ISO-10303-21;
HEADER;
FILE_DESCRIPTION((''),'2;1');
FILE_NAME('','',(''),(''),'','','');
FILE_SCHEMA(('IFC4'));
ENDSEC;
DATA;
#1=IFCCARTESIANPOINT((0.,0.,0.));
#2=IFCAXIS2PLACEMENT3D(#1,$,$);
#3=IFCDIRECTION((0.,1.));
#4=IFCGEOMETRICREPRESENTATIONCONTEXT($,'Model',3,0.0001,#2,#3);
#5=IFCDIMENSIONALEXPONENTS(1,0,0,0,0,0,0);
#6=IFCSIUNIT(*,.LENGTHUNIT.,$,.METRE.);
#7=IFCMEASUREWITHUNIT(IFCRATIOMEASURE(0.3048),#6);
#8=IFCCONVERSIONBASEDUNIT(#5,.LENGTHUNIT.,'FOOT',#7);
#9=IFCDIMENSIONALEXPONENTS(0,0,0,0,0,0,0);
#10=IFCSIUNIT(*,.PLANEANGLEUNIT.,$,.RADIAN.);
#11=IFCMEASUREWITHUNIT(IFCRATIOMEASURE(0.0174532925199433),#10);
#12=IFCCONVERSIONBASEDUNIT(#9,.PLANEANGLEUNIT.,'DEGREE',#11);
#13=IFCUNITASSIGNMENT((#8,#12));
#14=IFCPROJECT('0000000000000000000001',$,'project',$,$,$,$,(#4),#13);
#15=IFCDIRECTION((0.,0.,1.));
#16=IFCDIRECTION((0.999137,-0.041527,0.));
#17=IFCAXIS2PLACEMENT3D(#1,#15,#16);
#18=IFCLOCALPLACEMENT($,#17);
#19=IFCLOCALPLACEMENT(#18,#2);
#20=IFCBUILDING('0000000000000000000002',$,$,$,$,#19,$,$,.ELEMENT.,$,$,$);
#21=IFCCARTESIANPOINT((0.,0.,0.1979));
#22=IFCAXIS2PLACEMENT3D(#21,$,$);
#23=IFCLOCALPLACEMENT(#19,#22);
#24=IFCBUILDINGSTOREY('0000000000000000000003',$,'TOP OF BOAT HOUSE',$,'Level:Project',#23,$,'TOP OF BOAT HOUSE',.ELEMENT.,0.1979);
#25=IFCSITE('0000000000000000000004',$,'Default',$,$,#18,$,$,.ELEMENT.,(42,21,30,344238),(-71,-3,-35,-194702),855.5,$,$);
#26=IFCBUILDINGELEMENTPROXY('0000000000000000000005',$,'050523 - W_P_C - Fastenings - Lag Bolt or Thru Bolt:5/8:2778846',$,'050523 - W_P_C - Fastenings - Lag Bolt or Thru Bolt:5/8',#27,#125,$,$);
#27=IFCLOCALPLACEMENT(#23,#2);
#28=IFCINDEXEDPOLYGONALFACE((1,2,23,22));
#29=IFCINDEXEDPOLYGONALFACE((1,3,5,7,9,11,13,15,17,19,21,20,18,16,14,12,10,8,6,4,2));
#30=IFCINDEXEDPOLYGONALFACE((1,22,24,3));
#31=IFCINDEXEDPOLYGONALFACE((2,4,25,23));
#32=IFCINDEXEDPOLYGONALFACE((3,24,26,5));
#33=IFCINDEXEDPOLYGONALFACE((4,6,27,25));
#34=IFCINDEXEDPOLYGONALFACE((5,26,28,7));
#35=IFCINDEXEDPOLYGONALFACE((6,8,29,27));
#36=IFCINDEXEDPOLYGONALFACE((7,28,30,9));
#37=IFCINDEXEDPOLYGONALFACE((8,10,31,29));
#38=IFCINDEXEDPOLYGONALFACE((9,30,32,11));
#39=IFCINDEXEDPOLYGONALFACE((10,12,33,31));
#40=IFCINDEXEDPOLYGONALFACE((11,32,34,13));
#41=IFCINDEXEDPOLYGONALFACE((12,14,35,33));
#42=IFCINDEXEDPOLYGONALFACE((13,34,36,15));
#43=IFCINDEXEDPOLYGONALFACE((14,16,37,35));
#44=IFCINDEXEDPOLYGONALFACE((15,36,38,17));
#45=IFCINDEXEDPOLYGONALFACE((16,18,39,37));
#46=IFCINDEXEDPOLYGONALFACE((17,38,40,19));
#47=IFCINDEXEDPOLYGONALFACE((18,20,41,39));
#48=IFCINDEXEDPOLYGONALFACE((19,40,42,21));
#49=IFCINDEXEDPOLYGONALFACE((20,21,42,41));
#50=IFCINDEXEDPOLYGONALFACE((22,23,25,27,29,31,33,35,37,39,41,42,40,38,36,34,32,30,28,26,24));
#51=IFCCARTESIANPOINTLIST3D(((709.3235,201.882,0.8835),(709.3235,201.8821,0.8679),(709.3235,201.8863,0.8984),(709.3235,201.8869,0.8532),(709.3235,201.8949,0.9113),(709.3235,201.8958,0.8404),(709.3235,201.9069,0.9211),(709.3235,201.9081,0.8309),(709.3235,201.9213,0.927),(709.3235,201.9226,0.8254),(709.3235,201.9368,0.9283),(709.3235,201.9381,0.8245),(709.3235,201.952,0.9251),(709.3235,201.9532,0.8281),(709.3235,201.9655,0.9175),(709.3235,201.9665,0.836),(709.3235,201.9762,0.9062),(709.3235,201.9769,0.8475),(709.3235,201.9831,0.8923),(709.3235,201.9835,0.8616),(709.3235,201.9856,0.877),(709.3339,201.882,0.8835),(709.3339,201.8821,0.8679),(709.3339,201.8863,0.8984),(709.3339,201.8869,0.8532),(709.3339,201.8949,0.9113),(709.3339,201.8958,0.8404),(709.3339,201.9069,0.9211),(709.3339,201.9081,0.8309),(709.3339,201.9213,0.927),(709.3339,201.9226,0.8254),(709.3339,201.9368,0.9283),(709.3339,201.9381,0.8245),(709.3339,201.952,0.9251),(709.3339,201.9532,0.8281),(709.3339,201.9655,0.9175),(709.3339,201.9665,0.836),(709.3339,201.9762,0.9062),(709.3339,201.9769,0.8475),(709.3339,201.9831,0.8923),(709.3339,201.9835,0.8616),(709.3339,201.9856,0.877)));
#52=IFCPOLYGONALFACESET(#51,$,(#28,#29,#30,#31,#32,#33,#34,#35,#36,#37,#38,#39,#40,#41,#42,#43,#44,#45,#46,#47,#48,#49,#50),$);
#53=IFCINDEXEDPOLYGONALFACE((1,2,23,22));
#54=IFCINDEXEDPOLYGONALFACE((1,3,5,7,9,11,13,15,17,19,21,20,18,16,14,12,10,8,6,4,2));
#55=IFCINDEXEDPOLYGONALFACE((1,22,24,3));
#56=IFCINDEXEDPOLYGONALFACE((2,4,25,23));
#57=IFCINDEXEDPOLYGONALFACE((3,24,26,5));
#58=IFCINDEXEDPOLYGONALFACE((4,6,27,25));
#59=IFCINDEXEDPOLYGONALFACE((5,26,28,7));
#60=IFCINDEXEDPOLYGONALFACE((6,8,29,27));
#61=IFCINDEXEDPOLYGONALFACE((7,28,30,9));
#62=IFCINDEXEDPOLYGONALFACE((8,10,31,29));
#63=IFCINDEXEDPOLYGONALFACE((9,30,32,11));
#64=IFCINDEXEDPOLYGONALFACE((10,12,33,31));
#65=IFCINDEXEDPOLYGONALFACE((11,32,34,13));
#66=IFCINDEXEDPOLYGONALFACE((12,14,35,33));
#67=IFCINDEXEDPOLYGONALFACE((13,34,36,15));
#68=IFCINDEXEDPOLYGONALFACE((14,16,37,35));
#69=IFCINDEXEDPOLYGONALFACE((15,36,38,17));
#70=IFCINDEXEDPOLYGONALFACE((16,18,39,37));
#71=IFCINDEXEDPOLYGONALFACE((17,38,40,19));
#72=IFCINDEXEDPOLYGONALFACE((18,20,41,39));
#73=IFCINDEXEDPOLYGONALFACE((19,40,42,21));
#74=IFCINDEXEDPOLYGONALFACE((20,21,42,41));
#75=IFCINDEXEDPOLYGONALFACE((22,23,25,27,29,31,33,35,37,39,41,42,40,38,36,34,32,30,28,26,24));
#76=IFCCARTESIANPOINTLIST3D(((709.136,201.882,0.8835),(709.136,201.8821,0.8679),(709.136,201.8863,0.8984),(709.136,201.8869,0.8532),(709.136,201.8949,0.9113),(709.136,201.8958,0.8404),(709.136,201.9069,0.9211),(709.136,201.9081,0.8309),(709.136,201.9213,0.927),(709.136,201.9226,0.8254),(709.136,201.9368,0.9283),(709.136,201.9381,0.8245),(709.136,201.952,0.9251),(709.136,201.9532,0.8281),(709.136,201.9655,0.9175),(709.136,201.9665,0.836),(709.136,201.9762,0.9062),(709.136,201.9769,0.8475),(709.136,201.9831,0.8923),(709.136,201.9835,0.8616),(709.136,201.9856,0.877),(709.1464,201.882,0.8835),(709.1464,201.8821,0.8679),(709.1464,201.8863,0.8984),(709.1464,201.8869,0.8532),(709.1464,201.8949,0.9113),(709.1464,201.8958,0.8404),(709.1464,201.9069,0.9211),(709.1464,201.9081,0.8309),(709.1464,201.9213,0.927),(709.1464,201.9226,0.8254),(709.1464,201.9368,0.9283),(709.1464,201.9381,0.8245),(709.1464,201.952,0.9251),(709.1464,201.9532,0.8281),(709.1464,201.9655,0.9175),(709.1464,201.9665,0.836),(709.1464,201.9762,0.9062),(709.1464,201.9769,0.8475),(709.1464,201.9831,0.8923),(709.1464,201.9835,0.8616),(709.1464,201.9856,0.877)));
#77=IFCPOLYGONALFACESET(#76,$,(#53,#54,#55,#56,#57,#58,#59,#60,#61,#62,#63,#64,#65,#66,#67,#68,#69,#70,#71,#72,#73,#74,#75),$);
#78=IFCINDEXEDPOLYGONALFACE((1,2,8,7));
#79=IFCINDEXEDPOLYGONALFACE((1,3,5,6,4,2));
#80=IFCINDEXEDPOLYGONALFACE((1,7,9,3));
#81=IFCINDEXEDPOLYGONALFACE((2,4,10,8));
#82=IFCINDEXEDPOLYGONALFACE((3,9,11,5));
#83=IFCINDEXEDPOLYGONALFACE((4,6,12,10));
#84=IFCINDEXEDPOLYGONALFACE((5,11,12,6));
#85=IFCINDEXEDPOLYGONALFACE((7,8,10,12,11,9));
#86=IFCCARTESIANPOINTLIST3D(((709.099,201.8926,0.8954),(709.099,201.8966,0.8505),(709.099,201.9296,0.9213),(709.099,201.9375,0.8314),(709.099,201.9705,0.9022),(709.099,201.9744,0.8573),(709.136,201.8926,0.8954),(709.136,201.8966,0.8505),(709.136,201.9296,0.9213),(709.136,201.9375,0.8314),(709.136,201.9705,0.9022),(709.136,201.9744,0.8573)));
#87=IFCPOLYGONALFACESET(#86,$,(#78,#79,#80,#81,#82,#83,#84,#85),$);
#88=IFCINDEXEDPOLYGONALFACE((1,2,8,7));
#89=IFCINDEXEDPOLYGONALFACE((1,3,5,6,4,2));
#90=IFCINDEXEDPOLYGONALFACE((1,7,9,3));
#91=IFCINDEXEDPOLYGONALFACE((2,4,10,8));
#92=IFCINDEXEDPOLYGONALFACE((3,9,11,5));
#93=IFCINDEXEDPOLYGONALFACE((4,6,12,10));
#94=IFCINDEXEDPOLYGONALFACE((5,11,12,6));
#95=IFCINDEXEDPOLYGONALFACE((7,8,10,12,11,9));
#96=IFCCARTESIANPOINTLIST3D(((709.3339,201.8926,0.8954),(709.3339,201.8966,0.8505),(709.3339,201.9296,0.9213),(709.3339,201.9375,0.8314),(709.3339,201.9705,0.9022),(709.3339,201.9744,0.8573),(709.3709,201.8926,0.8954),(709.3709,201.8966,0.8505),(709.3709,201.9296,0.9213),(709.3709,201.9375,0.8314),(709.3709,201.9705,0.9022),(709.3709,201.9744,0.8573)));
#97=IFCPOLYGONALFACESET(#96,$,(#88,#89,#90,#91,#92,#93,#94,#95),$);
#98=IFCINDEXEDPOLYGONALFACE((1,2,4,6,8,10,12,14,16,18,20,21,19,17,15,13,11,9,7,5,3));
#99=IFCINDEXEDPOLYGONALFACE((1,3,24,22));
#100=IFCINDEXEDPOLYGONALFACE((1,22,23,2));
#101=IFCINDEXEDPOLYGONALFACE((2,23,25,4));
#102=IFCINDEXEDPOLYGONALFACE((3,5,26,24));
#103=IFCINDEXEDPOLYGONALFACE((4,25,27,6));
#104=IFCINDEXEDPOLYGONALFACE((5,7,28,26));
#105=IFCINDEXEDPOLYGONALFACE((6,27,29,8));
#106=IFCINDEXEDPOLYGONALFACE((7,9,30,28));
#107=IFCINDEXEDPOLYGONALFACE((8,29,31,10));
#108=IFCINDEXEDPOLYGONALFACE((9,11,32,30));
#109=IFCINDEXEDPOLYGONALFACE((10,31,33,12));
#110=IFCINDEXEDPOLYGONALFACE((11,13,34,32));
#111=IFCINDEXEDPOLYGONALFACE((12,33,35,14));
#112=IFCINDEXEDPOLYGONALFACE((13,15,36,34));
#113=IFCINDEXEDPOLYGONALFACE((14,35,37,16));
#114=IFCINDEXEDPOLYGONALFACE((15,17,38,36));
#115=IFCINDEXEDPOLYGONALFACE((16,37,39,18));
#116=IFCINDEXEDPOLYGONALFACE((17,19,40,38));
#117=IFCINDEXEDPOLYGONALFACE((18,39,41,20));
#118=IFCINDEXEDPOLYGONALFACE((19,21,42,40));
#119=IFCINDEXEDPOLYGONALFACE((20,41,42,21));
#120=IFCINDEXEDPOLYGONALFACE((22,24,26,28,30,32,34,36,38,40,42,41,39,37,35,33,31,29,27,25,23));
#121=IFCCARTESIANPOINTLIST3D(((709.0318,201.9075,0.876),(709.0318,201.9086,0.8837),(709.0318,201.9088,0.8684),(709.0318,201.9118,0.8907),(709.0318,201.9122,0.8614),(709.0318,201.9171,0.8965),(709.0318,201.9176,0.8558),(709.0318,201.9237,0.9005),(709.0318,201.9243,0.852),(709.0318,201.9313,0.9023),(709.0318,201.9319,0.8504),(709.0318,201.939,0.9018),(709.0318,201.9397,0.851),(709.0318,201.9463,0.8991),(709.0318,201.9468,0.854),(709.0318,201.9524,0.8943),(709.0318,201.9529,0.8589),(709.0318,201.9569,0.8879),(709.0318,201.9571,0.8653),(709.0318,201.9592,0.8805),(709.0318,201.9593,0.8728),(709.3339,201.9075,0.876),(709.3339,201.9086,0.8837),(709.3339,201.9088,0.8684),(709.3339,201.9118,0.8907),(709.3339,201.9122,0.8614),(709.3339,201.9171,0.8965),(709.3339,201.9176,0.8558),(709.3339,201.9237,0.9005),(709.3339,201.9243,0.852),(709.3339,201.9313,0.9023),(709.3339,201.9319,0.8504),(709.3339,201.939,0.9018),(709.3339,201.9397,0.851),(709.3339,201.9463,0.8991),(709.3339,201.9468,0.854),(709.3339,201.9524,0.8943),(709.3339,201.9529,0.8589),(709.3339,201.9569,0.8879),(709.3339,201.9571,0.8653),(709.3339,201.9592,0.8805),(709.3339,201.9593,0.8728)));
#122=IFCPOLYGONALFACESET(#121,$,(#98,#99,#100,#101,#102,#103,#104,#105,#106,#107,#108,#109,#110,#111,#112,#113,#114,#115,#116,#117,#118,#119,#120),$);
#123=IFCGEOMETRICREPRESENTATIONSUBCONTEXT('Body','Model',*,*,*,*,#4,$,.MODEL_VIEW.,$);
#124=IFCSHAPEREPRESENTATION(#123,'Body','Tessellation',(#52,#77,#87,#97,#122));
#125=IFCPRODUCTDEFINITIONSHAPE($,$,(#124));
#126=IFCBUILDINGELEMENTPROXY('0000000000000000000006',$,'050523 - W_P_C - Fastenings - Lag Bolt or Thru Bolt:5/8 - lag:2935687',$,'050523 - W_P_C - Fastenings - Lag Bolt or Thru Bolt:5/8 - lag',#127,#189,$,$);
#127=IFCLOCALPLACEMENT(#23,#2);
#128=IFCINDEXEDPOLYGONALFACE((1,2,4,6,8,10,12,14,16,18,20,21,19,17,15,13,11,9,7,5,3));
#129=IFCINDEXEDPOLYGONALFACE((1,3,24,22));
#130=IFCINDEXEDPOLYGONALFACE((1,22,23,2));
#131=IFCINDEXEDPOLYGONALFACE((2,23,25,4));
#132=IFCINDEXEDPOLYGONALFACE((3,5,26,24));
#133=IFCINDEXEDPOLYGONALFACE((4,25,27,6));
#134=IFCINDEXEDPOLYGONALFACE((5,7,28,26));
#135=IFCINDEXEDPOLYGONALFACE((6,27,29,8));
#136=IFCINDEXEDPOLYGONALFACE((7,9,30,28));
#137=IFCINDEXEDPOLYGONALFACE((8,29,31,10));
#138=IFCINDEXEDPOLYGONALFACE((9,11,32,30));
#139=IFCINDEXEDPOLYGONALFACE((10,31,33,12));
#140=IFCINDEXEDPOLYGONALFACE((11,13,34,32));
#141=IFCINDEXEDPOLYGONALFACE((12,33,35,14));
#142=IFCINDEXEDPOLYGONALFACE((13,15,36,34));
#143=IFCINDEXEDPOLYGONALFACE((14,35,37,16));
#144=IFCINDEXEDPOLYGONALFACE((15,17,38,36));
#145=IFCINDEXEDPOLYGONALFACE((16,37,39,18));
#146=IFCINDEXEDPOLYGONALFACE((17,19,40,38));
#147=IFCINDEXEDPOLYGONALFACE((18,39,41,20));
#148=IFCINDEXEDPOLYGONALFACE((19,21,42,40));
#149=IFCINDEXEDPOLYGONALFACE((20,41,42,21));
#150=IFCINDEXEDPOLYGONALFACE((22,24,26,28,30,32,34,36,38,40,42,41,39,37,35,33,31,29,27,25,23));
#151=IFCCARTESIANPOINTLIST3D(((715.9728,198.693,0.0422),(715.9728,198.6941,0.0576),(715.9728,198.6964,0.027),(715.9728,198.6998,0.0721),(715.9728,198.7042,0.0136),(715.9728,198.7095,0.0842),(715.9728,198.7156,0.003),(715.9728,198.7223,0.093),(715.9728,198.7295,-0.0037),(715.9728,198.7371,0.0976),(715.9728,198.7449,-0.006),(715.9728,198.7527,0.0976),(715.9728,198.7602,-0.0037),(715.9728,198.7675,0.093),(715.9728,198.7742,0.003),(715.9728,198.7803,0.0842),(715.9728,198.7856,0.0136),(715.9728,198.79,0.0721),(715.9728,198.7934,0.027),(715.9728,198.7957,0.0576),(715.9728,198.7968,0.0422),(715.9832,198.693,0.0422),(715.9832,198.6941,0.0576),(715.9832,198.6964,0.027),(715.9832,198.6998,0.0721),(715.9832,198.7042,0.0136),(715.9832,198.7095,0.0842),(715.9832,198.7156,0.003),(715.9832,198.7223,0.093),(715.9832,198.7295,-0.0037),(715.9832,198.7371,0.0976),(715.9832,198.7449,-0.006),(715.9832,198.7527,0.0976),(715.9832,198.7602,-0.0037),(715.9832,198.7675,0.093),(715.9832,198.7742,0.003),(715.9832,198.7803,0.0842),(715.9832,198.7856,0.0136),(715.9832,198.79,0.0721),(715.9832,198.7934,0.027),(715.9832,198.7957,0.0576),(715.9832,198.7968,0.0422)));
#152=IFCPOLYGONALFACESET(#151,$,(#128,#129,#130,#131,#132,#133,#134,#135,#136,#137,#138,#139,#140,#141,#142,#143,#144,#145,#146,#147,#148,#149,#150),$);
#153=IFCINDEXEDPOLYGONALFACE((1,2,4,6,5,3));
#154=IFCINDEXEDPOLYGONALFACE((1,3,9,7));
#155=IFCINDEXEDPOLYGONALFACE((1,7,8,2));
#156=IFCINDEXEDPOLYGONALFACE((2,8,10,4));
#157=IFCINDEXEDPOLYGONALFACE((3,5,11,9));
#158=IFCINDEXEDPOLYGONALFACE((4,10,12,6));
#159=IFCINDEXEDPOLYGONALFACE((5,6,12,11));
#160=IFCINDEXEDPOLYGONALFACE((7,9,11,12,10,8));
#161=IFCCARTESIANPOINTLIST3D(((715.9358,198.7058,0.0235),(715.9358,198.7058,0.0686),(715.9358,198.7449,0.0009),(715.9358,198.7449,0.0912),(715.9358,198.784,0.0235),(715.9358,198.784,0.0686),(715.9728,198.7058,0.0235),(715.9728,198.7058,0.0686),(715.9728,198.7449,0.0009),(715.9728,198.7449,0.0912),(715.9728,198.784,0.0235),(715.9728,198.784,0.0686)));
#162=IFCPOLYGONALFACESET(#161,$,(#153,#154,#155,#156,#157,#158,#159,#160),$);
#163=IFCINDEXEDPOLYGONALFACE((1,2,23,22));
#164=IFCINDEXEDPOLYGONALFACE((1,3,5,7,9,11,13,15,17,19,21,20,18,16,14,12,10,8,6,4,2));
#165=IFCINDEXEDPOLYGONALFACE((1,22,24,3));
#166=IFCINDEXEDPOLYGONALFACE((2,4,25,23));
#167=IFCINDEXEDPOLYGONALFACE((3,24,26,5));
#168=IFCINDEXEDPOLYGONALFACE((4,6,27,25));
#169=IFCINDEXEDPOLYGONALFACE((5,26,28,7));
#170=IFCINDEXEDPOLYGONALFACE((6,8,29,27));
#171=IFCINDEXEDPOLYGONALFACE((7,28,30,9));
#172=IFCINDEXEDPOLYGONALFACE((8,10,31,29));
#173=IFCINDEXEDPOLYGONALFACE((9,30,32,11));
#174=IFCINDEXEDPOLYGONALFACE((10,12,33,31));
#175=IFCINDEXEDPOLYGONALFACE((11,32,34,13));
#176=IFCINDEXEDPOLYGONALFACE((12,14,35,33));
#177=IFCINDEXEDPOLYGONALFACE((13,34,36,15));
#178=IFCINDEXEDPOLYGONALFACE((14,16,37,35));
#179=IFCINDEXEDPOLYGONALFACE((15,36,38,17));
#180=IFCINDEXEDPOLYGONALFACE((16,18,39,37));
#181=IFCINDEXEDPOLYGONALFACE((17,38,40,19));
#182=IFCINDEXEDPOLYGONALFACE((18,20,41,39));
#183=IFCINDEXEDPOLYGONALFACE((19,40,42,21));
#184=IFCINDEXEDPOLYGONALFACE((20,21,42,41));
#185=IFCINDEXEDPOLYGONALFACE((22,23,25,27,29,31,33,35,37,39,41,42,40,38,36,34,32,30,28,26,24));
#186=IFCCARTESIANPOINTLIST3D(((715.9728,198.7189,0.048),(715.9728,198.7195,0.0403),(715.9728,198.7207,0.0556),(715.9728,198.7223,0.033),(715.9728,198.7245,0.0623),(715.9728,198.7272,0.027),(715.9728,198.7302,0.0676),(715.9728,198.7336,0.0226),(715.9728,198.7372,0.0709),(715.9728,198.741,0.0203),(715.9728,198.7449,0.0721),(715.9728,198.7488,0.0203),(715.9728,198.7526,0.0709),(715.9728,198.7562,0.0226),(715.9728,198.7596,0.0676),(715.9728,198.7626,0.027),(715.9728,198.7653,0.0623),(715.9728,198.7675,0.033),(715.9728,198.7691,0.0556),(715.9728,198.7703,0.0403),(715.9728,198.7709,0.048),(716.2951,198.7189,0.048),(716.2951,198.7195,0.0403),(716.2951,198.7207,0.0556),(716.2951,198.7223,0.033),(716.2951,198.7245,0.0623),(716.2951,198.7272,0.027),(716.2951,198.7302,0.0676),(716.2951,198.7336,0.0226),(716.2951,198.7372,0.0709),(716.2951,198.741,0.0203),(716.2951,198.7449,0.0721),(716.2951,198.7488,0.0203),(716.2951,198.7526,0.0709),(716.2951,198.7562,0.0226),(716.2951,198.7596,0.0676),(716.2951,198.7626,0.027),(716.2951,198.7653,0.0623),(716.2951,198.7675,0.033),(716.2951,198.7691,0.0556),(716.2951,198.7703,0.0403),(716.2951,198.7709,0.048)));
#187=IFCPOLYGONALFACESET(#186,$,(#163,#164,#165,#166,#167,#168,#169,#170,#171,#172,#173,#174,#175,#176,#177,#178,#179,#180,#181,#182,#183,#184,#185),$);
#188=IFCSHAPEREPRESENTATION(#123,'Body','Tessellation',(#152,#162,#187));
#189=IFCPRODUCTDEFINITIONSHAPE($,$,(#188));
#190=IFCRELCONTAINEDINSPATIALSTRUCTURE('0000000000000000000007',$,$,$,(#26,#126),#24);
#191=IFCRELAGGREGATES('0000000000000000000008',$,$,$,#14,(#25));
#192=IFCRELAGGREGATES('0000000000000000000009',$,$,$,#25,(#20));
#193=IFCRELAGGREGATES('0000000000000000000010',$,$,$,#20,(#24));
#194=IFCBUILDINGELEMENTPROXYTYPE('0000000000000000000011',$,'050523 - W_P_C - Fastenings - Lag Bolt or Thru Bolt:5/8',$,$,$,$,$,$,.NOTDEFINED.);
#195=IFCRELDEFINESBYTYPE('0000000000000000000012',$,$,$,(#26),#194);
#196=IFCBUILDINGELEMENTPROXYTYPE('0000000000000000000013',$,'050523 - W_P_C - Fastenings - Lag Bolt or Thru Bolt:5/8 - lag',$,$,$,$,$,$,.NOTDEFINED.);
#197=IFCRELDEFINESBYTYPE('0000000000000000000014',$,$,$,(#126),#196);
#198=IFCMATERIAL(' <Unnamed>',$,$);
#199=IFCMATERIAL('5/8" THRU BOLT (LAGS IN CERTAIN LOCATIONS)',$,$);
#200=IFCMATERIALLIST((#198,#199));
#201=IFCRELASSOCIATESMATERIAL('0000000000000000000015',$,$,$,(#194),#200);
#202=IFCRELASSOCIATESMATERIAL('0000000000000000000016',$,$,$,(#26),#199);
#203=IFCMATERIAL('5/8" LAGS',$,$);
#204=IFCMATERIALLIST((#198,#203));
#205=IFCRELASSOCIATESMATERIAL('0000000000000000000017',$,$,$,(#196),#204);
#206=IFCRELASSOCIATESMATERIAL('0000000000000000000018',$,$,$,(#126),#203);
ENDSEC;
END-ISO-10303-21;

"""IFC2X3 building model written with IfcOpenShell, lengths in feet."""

from ifc_helpers import new_model, entity, si_unit, converted_unit, direction, frame, frame_2d, origin, place, context, subcontext, project, spatial, polyline, circle, outline, extrude, source, transform, mapped, material, material_list, type_object, type_shapes, element, save


model = new_model("IFC2X3")

# Units and contexts
model_context = context("Model", 3, precision=0.0001, world=origin(), true_north=direction((0.0, 1.0)))
body_context = subcontext(model_context, "Body", "Model", "MODEL_VIEW")
ifc_project = project(units=[converted_unit("LENGTHUNIT", "FOOT", entity("IfcRatioMeasure", 0.3048), si_unit("LENGTHUNIT", "METRE"), dimensions=[1, 0, 0, 0, 0, 0, 0]), converted_unit("PLANEANGLEUNIT", "DEGREE", entity("IfcRatioMeasure", 0.0174532925199433), si_unit("PLANEANGLEUNIT", "RADIAN"), dimensions=[0, 0, 0, 0, 0, 0, 0])], contexts=[model_context])

# Site, building, storey
site_placement = place(None, frame((0.0, 0.0, 0.0), z_axis=(0.0, 0.0, 1.0), x_axis=(0.999137, -0.041527, 0.0)))
site = spatial("IfcSite", under=ifc_project, at=site_placement, Name="Default", CompositionType="ELEMENT", RefLatitude=(42, 21, 30, 344238), RefLongitude=(-71, -3, -35, -194702), RefElevation=855.5)
building_placement = place(site_placement, origin())
building = spatial("IfcBuilding", under=site, at=building_placement, CompositionType="ELEMENT")
storey_placement = place(building_placement, frame((0.0, 0.0, 0.1979)))
storey = spatial("IfcBuildingStorey", under=building, at=storey_placement, Name="TOP OF BOAT HOUSE", ObjectType="Level:Project", LongName="TOP OF BOAT HOUSE", CompositionType="ELEMENT", Elevation=0.1979)

# Building element proxies
ifc_material_1 = material(Name="5/8\" THRU BOLT (LAGS IN CERTAIN LOCATIONS)")
ifc_material_2 = material(Name=" <Unnamed>")
ifc_material_list_1 = material_list([ifc_material_2, ifc_material_1])
building_element_proxy_type_1 = type_object("IfcBuildingElementProxyType", Name="050523 - W_P_C - Fastenings - Lag Bolt or Thru Bolt:5/8", PredefinedType="NOTDEFINED", material=ifc_material_list_1)
shared_shape_1 = source(origin(), body_context, "Body", "SweptSolid", [
    extrude(circle(Radius=0.0521, at=frame_2d((0.0, 0.0), x_axis=(1.0, 0.0))), frame((0.0, 0.0, 0.0), z_axis=(0.0, 0.0, 1.0), x_axis=(0.0, 1.0, 0.0)), (0.0, 0.0, 1.0), 0.0104),
    extrude(circle(Radius=0.0521, at=frame_2d((0.0, 0.0), x_axis=(1.0, 0.0))), frame((0.0, 0.0, -0.1875), z_axis=(0.0, 0.0, 1.0), x_axis=(0.0, 1.0, 0.0)), (0.0, 0.0, 1.0), 0.0104),
    extrude(outline(polyline([(-0.0226, -0.0391), (0.0226, -0.0391), (0.0451, 0.0), (0.0226, 0.0391), (-0.0226, 0.0391), (-0.0451, 0.0), (-0.0226, -0.0391)])), frame((0.0, 0.0, -0.2245), z_axis=(0.0, 0.0, 1.0), x_axis=(0.0, -1.0, 0.0)), (0.0, 0.0, 1.0), 0.037),
    extrude(outline(polyline([(-0.0226, -0.0391), (0.0226, -0.0391), (0.0451, 0.0), (0.0226, 0.0391), (-0.0226, 0.0391), (-0.0451, 0.0), (-0.0226, -0.0391)])), frame((0.0, 0.0, 0.0104), z_axis=(0.0, 0.0, 1.0), x_axis=(0.866025, -0.5, 0.0)), (0.0, 0.0, 1.0), 0.037),
    extrude(circle(Radius=0.026, at=frame_2d((0.0, 0.0), x_axis=(1.0, 0.0))), frame((0.0, 0.0, -0.2917), z_axis=(0.0, 0.0, 1.0), x_axis=(0.0, -1.0, 0.0)), (0.0, 0.0, 1.0), 0.3021),
])
type_shapes(building_element_proxy_type_1, [shared_shape_1])
for number, where, z_axis, x_axis, name in (
    (1, (709.3235, 201.9335, 0.8763), (1.0, 0.0, 0.0), (0.0, -0.996195, -0.087156), "050523 - W_P_C - Fastenings - Lag Bolt or Thru Bolt:5/8:2778846"),
):
    element("IfcBuildingElementProxy", number, at=place(storey_placement, frame(where, z_axis=z_axis, x_axis=x_axis)), inside=storey, type_object=building_element_proxy_type_1, material=ifc_material_1, Name=name, ObjectType="050523 - W_P_C - Fastenings - Lag Bolt or Thru Bolt:5/8", context=body_context, shape_type="MappedRepresentation", body=[
        mapped(shared_shape_1, transform((0.0, 0.0, 0.0), scale=1.0)),
    ])
ifc_material_3 = material(Name="5/8\" LAGS")
ifc_material_list_2 = material_list([ifc_material_2, ifc_material_3])
building_element_proxy_type_2 = type_object("IfcBuildingElementProxyType", Name="050523 - W_P_C - Fastenings - Lag Bolt or Thru Bolt:5/8 - lag", PredefinedType="NOTDEFINED", material=ifc_material_list_2)
shared_shape_2 = source(origin(), body_context, "Body", "SweptSolid", [
    extrude(circle(Radius=0.0521, at=frame_2d((0.0, 0.0), x_axis=(1.0, 0.0))), frame((0.0, 0.0, 0.0), z_axis=(0.0, 0.0, 1.0), x_axis=(0.0, -1.0, 0.0)), (0.0, 0.0, 1.0), 0.0104),
    extrude(outline(polyline([(-0.0226, -0.0391), (0.0226, -0.0391), (0.0451, 0.0), (0.0226, 0.0391), (-0.0226, 0.0391), (-0.0451, 0.0), (-0.0226, -0.0391)])), frame((0.0, 0.0, 0.0104), z_axis=(0.0, 0.0, 1.0), x_axis=(0.0, -1.0, 0.0)), (0.0, 0.0, 1.0), 0.037),
    extrude(circle(Radius=0.026, at=frame_2d((0.0, 0.0), x_axis=(1.0, 0.0))), frame((0.0, 0.0, -0.312), z_axis=(0.0, 0.0, 1.0), x_axis=(0.0, 1.0, 0.0)), (0.0, 0.0, 1.0), 0.3224),
])
type_shapes(building_element_proxy_type_2, [shared_shape_2])
for number, where, z_axis, x_axis, name in (
    (2, (715.9832, 198.7449, 0.0461), (-1.0, 0.0, 0.0), (0.0, -1.0, 0.0), "050523 - W_P_C - Fastenings - Lag Bolt or Thru Bolt:5/8 - lag:2935687"),
):
    element("IfcBuildingElementProxy", number, at=place(storey_placement, frame(where, z_axis=z_axis, x_axis=x_axis)), inside=storey, type_object=building_element_proxy_type_2, material=ifc_material_3, Name=name, ObjectType="050523 - W_P_C - Fastenings - Lag Bolt or Thru Bolt:5/8 - lag", context=body_context, shape_type="MappedRepresentation", body=[
        mapped(shared_shape_2, transform((0.0, 0.0, 0.0), scale=1.0)),
    ])

save(model, "model.ifc")
